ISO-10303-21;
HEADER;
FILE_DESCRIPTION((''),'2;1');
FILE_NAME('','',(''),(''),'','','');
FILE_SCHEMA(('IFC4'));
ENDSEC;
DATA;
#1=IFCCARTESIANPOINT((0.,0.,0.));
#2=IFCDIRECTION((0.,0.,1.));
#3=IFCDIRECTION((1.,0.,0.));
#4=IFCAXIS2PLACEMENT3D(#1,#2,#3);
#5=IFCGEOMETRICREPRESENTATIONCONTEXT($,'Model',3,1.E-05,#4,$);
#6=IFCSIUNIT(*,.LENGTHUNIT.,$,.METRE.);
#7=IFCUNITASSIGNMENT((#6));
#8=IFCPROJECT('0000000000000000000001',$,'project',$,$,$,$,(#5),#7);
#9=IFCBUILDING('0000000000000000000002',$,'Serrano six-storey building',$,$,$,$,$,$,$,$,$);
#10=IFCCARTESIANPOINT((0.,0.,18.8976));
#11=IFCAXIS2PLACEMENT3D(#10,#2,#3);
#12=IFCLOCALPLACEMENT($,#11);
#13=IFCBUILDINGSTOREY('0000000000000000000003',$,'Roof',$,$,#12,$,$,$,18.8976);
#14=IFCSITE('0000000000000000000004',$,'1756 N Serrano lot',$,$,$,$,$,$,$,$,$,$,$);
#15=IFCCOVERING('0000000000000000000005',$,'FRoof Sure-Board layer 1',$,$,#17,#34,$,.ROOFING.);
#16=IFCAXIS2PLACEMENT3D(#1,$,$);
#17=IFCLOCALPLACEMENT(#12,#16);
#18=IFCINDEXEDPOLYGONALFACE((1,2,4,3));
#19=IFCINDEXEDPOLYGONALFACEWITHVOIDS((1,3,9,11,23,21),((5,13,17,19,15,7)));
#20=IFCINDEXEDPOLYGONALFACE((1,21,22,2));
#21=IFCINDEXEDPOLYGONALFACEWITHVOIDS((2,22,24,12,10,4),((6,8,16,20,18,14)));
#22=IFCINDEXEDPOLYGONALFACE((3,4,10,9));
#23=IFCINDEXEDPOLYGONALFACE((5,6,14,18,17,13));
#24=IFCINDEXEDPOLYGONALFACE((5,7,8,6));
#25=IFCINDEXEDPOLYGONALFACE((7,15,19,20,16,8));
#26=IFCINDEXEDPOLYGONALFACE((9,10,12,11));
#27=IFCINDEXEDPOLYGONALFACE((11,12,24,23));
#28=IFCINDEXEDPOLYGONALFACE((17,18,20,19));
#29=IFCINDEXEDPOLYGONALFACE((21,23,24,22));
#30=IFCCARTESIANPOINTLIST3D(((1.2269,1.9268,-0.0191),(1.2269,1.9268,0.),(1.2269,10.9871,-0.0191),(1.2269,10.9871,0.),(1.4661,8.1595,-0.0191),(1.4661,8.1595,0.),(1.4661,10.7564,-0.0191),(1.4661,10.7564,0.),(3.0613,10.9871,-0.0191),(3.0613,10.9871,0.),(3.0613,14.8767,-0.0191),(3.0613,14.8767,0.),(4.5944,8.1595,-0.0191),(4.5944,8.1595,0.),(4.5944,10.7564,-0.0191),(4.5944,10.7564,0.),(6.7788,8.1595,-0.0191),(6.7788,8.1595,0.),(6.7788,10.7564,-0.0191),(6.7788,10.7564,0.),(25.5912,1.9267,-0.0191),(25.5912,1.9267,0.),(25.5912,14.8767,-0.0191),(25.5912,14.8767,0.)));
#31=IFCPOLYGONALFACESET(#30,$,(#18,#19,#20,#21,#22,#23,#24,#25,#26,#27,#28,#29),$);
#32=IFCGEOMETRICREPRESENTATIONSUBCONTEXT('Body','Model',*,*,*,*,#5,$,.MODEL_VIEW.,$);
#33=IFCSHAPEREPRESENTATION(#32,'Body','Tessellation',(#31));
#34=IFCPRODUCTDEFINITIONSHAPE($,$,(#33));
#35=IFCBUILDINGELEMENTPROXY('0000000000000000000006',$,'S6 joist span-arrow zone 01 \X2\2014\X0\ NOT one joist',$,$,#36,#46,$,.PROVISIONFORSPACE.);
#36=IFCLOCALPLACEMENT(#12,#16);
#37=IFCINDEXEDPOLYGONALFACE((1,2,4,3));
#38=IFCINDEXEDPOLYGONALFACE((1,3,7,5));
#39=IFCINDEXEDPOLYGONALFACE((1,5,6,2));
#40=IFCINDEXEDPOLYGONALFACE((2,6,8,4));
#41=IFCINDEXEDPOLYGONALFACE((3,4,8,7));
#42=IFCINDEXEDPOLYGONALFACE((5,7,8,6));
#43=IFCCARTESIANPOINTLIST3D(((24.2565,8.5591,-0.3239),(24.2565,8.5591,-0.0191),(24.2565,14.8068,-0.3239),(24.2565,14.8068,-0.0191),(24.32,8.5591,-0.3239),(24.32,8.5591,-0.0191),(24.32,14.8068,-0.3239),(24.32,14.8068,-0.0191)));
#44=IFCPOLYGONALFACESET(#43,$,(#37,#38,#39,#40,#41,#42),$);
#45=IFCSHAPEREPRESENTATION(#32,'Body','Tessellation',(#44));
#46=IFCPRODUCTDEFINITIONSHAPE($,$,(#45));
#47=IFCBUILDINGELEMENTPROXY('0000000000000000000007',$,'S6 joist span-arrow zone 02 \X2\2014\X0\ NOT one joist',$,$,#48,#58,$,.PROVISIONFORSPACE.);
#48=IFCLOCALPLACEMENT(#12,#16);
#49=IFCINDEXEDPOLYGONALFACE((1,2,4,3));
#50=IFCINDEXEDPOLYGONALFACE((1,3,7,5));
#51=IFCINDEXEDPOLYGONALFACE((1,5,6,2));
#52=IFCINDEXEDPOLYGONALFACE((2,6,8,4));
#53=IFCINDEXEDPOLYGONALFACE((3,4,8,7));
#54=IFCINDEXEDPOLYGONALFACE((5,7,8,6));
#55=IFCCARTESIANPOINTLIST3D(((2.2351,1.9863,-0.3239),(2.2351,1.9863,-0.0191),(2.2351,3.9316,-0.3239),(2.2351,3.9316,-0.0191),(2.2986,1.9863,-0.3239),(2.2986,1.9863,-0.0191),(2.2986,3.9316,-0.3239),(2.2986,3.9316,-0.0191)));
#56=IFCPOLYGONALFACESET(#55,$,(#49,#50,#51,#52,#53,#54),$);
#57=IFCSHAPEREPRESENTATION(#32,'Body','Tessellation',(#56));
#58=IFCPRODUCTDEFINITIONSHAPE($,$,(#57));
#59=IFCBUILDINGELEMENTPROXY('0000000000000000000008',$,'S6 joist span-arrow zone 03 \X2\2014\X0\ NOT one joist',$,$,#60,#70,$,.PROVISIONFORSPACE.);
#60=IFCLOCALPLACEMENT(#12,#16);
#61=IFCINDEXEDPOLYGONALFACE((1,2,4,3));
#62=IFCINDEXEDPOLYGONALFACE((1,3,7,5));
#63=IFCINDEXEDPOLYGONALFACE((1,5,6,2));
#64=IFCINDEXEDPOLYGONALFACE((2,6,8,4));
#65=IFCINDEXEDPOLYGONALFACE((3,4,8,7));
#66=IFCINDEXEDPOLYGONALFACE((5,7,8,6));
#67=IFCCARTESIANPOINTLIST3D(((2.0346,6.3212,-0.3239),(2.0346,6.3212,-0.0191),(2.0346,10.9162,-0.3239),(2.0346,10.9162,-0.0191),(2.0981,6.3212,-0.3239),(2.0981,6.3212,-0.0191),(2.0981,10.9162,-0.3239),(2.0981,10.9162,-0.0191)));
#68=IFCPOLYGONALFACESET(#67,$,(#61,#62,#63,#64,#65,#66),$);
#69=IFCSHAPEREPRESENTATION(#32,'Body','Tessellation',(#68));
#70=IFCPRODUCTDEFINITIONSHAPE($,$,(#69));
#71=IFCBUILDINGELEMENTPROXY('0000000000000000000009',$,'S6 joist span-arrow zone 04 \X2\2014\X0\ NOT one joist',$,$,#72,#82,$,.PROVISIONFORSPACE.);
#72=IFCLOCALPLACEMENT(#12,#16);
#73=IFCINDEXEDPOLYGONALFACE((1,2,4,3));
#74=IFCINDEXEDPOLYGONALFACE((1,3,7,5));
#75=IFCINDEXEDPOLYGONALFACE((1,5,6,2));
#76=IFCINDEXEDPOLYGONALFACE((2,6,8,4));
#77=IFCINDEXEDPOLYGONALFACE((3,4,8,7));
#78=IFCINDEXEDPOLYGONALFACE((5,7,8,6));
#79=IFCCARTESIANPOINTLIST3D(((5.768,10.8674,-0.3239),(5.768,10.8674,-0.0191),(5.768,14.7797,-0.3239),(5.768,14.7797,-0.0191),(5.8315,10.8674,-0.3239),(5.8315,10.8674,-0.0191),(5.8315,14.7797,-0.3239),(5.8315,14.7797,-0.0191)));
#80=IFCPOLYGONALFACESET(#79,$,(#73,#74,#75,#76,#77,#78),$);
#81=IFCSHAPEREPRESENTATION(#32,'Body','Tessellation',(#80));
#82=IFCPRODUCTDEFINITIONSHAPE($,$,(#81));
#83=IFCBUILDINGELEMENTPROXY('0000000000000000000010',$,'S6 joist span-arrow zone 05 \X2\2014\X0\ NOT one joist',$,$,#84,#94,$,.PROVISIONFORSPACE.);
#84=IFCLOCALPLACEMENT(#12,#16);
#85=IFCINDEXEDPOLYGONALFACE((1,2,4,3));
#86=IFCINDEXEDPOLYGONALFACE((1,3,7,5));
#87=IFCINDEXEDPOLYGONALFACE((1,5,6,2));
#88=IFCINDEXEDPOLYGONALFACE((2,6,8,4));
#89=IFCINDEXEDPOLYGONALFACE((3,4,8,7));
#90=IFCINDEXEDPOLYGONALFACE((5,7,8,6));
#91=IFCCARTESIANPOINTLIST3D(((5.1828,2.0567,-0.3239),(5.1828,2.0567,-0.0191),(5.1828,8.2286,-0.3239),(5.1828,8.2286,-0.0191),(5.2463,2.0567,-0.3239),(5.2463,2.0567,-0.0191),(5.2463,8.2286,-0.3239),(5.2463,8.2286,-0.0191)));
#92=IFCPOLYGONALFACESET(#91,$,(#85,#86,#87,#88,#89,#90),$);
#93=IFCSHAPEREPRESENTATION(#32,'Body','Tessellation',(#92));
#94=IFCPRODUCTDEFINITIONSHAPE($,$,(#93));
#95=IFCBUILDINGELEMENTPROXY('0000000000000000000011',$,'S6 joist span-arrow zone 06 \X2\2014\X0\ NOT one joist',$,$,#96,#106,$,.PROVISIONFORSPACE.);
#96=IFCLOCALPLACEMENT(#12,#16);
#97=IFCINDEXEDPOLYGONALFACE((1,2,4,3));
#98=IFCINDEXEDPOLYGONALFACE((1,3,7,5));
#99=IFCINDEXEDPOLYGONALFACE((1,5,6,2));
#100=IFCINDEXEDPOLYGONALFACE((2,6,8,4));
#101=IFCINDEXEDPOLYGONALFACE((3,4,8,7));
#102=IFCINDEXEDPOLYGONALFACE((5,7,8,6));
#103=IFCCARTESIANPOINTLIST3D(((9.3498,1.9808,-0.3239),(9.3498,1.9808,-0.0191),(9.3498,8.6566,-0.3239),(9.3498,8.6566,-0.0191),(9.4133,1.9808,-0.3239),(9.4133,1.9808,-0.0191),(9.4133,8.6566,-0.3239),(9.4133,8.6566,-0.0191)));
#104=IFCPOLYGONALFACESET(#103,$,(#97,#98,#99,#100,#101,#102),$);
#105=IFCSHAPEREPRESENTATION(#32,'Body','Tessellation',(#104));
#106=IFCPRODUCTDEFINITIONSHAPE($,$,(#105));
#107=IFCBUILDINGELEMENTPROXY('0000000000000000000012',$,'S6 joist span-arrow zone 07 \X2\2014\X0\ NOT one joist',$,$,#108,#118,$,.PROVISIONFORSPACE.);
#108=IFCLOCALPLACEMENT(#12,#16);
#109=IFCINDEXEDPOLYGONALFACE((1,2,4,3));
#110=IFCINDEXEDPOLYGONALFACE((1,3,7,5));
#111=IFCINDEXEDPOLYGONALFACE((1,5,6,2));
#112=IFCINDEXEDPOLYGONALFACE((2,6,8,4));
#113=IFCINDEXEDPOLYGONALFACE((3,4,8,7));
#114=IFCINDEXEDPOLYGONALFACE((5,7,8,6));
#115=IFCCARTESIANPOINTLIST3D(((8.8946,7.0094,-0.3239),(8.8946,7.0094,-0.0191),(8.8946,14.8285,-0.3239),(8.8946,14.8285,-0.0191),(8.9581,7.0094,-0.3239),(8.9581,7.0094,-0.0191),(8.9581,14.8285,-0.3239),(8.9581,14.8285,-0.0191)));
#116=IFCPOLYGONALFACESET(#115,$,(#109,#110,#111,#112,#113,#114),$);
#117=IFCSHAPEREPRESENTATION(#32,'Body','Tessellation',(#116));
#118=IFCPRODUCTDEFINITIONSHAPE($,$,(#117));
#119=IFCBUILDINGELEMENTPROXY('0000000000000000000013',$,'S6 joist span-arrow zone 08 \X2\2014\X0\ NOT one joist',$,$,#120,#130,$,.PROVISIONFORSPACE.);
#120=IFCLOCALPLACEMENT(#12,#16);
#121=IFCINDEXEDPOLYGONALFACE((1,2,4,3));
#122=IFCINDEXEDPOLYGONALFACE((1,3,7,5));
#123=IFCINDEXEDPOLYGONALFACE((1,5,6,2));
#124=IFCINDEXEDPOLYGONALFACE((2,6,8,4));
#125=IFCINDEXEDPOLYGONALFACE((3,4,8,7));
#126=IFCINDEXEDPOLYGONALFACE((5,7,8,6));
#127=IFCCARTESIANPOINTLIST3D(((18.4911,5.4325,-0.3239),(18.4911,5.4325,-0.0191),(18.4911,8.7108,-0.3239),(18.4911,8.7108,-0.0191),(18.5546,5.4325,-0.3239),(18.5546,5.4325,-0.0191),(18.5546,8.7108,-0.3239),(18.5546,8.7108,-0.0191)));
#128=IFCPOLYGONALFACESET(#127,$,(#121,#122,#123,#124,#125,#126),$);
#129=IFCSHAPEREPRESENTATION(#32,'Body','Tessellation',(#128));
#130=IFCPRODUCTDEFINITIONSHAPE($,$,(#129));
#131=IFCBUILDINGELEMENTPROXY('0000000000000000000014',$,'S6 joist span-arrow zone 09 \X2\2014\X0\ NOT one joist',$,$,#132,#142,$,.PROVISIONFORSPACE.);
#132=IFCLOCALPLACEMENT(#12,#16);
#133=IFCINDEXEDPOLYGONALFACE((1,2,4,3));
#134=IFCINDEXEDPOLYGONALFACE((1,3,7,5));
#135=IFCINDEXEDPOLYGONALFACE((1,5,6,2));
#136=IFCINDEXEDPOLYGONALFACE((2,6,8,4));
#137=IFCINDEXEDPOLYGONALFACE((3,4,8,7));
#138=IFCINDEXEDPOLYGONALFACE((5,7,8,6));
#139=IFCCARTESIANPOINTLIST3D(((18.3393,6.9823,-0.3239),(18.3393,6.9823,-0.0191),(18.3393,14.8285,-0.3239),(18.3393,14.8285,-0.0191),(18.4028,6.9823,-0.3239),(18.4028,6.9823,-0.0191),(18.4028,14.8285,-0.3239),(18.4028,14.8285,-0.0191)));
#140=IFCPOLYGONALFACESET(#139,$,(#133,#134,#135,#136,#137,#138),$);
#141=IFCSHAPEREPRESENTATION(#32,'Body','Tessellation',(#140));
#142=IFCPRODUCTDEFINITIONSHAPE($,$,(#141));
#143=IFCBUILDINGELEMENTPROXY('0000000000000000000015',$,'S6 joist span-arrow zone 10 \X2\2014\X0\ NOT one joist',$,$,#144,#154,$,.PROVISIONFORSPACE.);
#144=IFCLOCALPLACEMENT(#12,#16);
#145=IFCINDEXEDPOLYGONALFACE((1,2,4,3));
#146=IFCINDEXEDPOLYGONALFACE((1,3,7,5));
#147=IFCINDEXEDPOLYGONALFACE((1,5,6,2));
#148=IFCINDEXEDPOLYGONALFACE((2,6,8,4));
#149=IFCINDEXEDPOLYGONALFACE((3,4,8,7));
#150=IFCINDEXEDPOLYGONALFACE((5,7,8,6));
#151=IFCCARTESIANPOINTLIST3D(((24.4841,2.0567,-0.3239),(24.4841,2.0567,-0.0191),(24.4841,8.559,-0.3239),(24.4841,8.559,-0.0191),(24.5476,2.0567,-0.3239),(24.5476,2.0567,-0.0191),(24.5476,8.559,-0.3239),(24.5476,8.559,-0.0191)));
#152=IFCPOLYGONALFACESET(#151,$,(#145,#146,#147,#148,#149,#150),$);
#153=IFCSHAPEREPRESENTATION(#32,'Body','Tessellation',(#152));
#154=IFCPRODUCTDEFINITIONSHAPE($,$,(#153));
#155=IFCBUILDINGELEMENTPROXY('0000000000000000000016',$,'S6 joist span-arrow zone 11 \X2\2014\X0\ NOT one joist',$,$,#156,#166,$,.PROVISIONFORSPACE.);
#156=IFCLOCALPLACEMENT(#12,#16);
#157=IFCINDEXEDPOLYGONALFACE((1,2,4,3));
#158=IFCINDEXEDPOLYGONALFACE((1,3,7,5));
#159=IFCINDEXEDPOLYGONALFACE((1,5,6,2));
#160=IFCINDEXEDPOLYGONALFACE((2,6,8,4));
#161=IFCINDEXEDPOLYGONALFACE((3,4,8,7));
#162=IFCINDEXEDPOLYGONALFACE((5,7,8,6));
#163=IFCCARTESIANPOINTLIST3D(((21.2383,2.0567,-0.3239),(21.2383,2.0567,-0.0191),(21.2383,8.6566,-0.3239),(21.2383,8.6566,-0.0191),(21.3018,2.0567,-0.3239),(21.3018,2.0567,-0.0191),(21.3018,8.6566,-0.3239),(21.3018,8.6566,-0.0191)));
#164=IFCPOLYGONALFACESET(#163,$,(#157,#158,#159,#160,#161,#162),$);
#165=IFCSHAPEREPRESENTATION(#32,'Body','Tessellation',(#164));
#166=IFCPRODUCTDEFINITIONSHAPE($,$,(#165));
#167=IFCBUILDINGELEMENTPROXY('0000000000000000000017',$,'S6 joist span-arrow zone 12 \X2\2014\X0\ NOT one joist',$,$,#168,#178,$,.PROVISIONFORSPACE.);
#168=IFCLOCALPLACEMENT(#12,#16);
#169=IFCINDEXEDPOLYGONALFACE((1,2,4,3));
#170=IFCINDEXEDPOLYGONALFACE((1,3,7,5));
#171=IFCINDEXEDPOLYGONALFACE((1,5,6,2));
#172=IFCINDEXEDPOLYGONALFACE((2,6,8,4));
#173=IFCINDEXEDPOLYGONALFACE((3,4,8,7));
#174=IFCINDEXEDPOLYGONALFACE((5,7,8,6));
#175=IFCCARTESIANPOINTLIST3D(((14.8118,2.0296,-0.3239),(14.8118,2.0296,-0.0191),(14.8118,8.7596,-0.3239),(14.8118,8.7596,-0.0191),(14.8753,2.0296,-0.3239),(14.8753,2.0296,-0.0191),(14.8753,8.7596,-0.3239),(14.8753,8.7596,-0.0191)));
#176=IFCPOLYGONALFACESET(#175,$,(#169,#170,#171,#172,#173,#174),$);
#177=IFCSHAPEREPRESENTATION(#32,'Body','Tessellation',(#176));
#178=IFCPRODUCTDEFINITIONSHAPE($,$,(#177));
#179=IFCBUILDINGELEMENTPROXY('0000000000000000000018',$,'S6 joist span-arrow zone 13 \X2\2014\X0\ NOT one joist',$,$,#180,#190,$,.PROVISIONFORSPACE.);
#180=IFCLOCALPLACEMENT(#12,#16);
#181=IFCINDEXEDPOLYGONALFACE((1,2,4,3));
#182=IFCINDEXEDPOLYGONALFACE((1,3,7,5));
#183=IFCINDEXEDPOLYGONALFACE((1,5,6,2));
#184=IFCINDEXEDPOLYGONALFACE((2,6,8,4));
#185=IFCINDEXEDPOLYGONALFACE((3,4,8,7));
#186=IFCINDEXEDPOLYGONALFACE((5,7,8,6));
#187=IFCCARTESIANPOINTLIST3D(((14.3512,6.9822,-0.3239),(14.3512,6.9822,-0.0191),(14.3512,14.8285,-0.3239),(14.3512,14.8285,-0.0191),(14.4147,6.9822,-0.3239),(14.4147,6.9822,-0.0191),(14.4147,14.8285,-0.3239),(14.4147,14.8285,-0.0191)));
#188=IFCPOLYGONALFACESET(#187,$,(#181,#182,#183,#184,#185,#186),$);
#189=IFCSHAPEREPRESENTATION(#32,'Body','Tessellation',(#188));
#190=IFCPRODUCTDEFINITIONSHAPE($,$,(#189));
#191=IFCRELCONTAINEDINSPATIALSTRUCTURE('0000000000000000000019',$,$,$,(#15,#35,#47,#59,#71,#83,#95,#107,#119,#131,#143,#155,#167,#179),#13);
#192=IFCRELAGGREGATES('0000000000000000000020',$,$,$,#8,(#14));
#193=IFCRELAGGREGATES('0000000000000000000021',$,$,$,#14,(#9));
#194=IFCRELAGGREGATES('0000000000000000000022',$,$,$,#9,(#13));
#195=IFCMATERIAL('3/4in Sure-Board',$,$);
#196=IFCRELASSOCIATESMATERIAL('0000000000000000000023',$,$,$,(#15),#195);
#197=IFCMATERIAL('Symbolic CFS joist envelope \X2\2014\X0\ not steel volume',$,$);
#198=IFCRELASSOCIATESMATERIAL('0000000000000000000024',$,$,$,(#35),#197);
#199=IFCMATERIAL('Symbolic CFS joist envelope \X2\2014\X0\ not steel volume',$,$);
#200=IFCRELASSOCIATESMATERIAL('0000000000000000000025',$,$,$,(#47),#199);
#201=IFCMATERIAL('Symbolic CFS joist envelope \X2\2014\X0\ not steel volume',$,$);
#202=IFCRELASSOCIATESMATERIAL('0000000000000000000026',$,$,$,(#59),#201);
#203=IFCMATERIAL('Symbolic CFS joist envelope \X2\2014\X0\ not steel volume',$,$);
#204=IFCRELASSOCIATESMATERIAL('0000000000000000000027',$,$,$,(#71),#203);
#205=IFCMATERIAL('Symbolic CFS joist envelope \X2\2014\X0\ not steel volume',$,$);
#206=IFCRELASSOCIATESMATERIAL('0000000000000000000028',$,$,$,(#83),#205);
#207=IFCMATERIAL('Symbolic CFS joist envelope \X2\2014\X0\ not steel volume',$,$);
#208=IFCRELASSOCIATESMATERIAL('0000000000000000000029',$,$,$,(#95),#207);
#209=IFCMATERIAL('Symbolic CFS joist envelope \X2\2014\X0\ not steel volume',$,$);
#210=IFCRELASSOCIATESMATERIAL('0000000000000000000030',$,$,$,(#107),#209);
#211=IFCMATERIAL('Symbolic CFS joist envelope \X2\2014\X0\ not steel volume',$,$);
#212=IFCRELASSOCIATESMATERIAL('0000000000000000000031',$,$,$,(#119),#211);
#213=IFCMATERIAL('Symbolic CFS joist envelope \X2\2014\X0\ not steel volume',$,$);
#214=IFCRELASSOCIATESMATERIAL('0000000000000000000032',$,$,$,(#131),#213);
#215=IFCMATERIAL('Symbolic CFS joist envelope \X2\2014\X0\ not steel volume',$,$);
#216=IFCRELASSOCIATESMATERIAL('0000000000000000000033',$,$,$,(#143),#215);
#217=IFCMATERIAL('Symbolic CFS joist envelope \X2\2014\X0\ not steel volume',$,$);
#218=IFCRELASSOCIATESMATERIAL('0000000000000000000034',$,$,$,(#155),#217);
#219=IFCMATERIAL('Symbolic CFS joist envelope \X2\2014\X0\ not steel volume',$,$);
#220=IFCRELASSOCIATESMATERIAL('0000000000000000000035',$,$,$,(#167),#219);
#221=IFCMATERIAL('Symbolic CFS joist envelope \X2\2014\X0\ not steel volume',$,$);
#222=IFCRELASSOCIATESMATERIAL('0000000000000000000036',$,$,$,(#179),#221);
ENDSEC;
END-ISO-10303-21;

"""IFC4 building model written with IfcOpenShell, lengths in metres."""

from ifc_helpers import new_model, si_unit, frame, origin_with_axes, place, context, subcontext, project, spatial, polyline, outline, extrude, material, element, save


model = new_model("IFC4")

# Units and contexts
model_context = context("Model", 3, precision=1e-05, world=origin_with_axes())
body_context = subcontext(model_context, "Body", "Model", "MODEL_VIEW")
ifc_project = project(units=[si_unit("LENGTHUNIT", "METRE")], contexts=[model_context])

# Site, building, storey
site = spatial("IfcSite", under=ifc_project, Name="1756 N Serrano lot")
building = spatial("IfcBuilding", under=site, Name="Serrano six-storey building")
storey_placement = place(None, frame((0.0, 0.0, 18.8976), z_axis=(0.0, 0.0, 1.0), x_axis=(1.0, 0.0, 0.0)))
storey = spatial("IfcBuildingStorey", under=building, at=storey_placement, Name="Roof", Elevation=18.8976)

# Covering
ifc_material_1 = material(Name="3/4in Sure-Board")
covering_placement = place(storey_placement, frame((0.0, 0.0, -18.8976), z_axis=(0.0, 0.0, 1.0), x_axis=(1.0, 0.0, 0.0)))
element("IfcCovering", 1, at=covering_placement, inside=storey, material=ifc_material_1, Name="FRoof Sure-Board layer 1", PredefinedType="ROOFING", context=body_context, shape_type="SweptSolid", body=[
    extrude(outline(polyline([(25.5912, 1.9267), (1.2269, 1.9268), (1.2269, 10.9871), (3.0613, 10.9871), (3.0613, 14.8767), (25.5912, 14.8767), (25.5912, 1.9267)]), holes=[polyline([(1.4661, 10.7564), (1.4661, 8.1595), (4.5944, 8.1595), (6.7788, 8.1595), (6.7788, 10.7564), (4.5944, 10.7564), (1.4661, 10.7564)])]), frame((0.0, 0.0, 18.8786)), (0.0, 0.0, 1.0), 0.0191),
])

# Building element proxies
ifc_material_2 = material(Name="Symbolic CFS joist envelope — not steel volume")
proxy_1_placement = place(storey_placement, frame((0.0, 0.0, -18.8976), z_axis=(0.0, 0.0, 1.0), x_axis=(1.0, 0.0, 0.0)))
element("IfcBuildingElementProxy", 2, at=proxy_1_placement, inside=storey, material=ifc_material_2, Name="S6 joist span-arrow zone 01 — NOT one joist", PredefinedType="PROVISIONFORSPACE", context=body_context, shape_type="SweptSolid", body=[
    extrude(outline(polyline([(24.2565, 14.8068), (24.32, 14.8068), (24.32, 8.5591), (24.2565, 8.5591), (24.2565, 14.8068)])), frame((0.0, 0.0, 18.5738)), (0.0, 0.0, 1.0), 0.3048),
])
ifc_material_3 = material(Name="Symbolic CFS joist envelope — not steel volume")
proxy_2_placement = place(storey_placement, frame((0.0, 0.0, -18.8976), z_axis=(0.0, 0.0, 1.0), x_axis=(1.0, 0.0, 0.0)))
element("IfcBuildingElementProxy", 3, at=proxy_2_placement, inside=storey, material=ifc_material_3, Name="S6 joist span-arrow zone 02 — NOT one joist", PredefinedType="PROVISIONFORSPACE", context=body_context, shape_type="SweptSolid", body=[
    extrude(outline(polyline([(2.2351, 3.9316), (2.2986, 3.9316), (2.2986, 1.9863), (2.2351, 1.9863), (2.2351, 3.9316)])), frame((0.0, 0.0, 18.5738)), (0.0, 0.0, 1.0), 0.3048),
])
ifc_material_4 = material(Name="Symbolic CFS joist envelope — not steel volume")
proxy_3_placement = place(storey_placement, frame((0.0, 0.0, -18.8976), z_axis=(0.0, 0.0, 1.0), x_axis=(1.0, 0.0, 0.0)))
element("IfcBuildingElementProxy", 4, at=proxy_3_placement, inside=storey, material=ifc_material_4, Name="S6 joist span-arrow zone 03 — NOT one joist", PredefinedType="PROVISIONFORSPACE", context=body_context, shape_type="SweptSolid", body=[
    extrude(outline(polyline([(2.0346, 10.9162), (2.0981, 10.9162), (2.0981, 6.3212), (2.0346, 6.3212), (2.0346, 10.9162)])), frame((0.0, 0.0, 18.5738)), (0.0, 0.0, 1.0), 0.3048),
])
ifc_material_5 = material(Name="Symbolic CFS joist envelope — not steel volume")
proxy_4_placement = place(storey_placement, frame((0.0, 0.0, -18.8976), z_axis=(0.0, 0.0, 1.0), x_axis=(1.0, 0.0, 0.0)))
element("IfcBuildingElementProxy", 5, at=proxy_4_placement, inside=storey, material=ifc_material_5, Name="S6 joist span-arrow zone 04 — NOT one joist", PredefinedType="PROVISIONFORSPACE", context=body_context, shape_type="SweptSolid", body=[
    extrude(outline(polyline([(5.768, 14.7797), (5.8315, 14.7797), (5.8315, 10.8674), (5.768, 10.8674), (5.768, 14.7797)])), frame((0.0, 0.0, 18.5738)), (0.0, 0.0, 1.0), 0.3048),
])
ifc_material_6 = material(Name="Symbolic CFS joist envelope — not steel volume")
proxy_5_placement = place(storey_placement, frame((0.0, 0.0, -18.8976), z_axis=(0.0, 0.0, 1.0), x_axis=(1.0, 0.0, 0.0)))
element("IfcBuildingElementProxy", 6, at=proxy_5_placement, inside=storey, material=ifc_material_6, Name="S6 joist span-arrow zone 05 — NOT one joist", PredefinedType="PROVISIONFORSPACE", context=body_context, shape_type="SweptSolid", body=[
    extrude(outline(polyline([(5.1828, 8.2286), (5.2463, 8.2286), (5.2463, 2.0567), (5.1828, 2.0567), (5.1828, 8.2286)])), frame((0.0, 0.0, 18.5738)), (0.0, 0.0, 1.0), 0.3048),
])
ifc_material_7 = material(Name="Symbolic CFS joist envelope — not steel volume")
proxy_6_placement = place(storey_placement, frame((0.0, 0.0, -18.8976), z_axis=(0.0, 0.0, 1.0), x_axis=(1.0, 0.0, 0.0)))
element("IfcBuildingElementProxy", 7, at=proxy_6_placement, inside=storey, material=ifc_material_7, Name="S6 joist span-arrow zone 06 — NOT one joist", PredefinedType="PROVISIONFORSPACE", context=body_context, shape_type="SweptSolid", body=[
    extrude(outline(polyline([(9.3498, 8.6566), (9.4133, 8.6566), (9.4133, 1.9808), (9.3498, 1.9808), (9.3498, 8.6566)])), frame((0.0, 0.0, 18.5738)), (0.0, 0.0, 1.0), 0.3048),
])
ifc_material_8 = material(Name="Symbolic CFS joist envelope — not steel volume")
proxy_7_placement = place(storey_placement, frame((0.0, 0.0, -18.8976), z_axis=(0.0, 0.0, 1.0), x_axis=(1.0, 0.0, 0.0)))
element("IfcBuildingElementProxy", 8, at=proxy_7_placement, inside=storey, material=ifc_material_8, Name="S6 joist span-arrow zone 07 — NOT one joist", PredefinedType="PROVISIONFORSPACE", context=body_context, shape_type="SweptSolid", body=[
    extrude(outline(polyline([(8.8946, 14.8285), (8.9581, 14.8285), (8.9581, 7.0094), (8.8946, 7.0094), (8.8946, 14.8285)])), frame((0.0, 0.0, 18.5738)), (0.0, 0.0, 1.0), 0.3048),
])
ifc_material_9 = material(Name="Symbolic CFS joist envelope — not steel volume")
proxy_8_placement = place(storey_placement, frame((0.0, 0.0, -18.8976), z_axis=(0.0, 0.0, 1.0), x_axis=(1.0, 0.0, 0.0)))
element("IfcBuildingElementProxy", 9, at=proxy_8_placement, inside=storey, material=ifc_material_9, Name="S6 joist span-arrow zone 08 — NOT one joist", PredefinedType="PROVISIONFORSPACE", context=body_context, shape_type="SweptSolid", body=[
    extrude(outline(polyline([(18.4911, 8.7108), (18.5546, 8.7108), (18.5546, 5.4325), (18.4911, 5.4325), (18.4911, 8.7108)])), frame((0.0, 0.0, 18.5738)), (0.0, 0.0, 1.0), 0.3048),
])
ifc_material_10 = material(Name="Symbolic CFS joist envelope — not steel volume")
proxy_9_placement = place(storey_placement, frame((0.0, 0.0, -18.8976), z_axis=(0.0, 0.0, 1.0), x_axis=(1.0, 0.0, 0.0)))
element("IfcBuildingElementProxy", 10, at=proxy_9_placement, inside=storey, material=ifc_material_10, Name="S6 joist span-arrow zone 09 — NOT one joist", PredefinedType="PROVISIONFORSPACE", context=body_context, shape_type="SweptSolid", body=[
    extrude(outline(polyline([(18.3393, 14.8285), (18.4028, 14.8285), (18.4028, 6.9823), (18.3393, 6.9823), (18.3393, 14.8285)])), frame((0.0, 0.0, 18.5738)), (0.0, 0.0, 1.0), 0.3048),
])
ifc_material_11 = material(Name="Symbolic CFS joist envelope — not steel volume")
proxy_10_placement = place(storey_placement, frame((0.0, 0.0, -18.8976), z_axis=(0.0, 0.0, 1.0), x_axis=(1.0, 0.0, 0.0)))
element("IfcBuildingElementProxy", 11, at=proxy_10_placement, inside=storey, material=ifc_material_11, Name="S6 joist span-arrow zone 10 — NOT one joist", PredefinedType="PROVISIONFORSPACE", context=body_context, shape_type="SweptSolid", body=[
    extrude(outline(polyline([(24.4841, 8.559), (24.5476, 8.559), (24.5476, 2.0567), (24.4841, 2.0567), (24.4841, 8.559)])), frame((0.0, 0.0, 18.5738)), (0.0, 0.0, 1.0), 0.3048),
])
ifc_material_12 = material(Name="Symbolic CFS joist envelope — not steel volume")
proxy_11_placement = place(storey_placement, frame((0.0, 0.0, -18.8976), z_axis=(0.0, 0.0, 1.0), x_axis=(1.0, 0.0, 0.0)))
element("IfcBuildingElementProxy", 12, at=proxy_11_placement, inside=storey, material=ifc_material_12, Name="S6 joist span-arrow zone 11 — NOT one joist", PredefinedType="PROVISIONFORSPACE", context=body_context, shape_type="SweptSolid", body=[
    extrude(outline(polyline([(21.2383, 8.6566), (21.3018, 8.6566), (21.3018, 2.0567), (21.2383, 2.0567), (21.2383, 8.6566)])), frame((0.0, 0.0, 18.5738)), (0.0, 0.0, 1.0), 0.3048),
])
ifc_material_13 = material(Name="Symbolic CFS joist envelope — not steel volume")
proxy_12_placement = place(storey_placement, frame((0.0, 0.0, -18.8976), z_axis=(0.0, 0.0, 1.0), x_axis=(1.0, 0.0, 0.0)))
element("IfcBuildingElementProxy", 13, at=proxy_12_placement, inside=storey, material=ifc_material_13, Name="S6 joist span-arrow zone 12 — NOT one joist", PredefinedType="PROVISIONFORSPACE", context=body_context, shape_type="SweptSolid", body=[
    extrude(outline(polyline([(14.8118, 8.7596), (14.8753, 8.7596), (14.8753, 2.0296), (14.8118, 2.0296), (14.8118, 8.7596)])), frame((0.0, 0.0, 18.5738)), (0.0, 0.0, 1.0), 0.3048),
])
ifc_material_14 = material(Name="Symbolic CFS joist envelope — not steel volume")
proxy_13_placement = place(storey_placement, frame((0.0, 0.0, -18.8976), z_axis=(0.0, 0.0, 1.0), x_axis=(1.0, 0.0, 0.0)))
element("IfcBuildingElementProxy", 14, at=proxy_13_placement, inside=storey, material=ifc_material_14, Name="S6 joist span-arrow zone 13 — NOT one joist", PredefinedType="PROVISIONFORSPACE", context=body_context, shape_type="SweptSolid", body=[
    extrude(outline(polyline([(14.3512, 14.8285), (14.4147, 14.8285), (14.4147, 6.9822), (14.3512, 6.9822), (14.3512, 14.8285)])), frame((0.0, 0.0, 18.5738)), (0.0, 0.0, 1.0), 0.3048),
])

save(model, "model.ifc")
